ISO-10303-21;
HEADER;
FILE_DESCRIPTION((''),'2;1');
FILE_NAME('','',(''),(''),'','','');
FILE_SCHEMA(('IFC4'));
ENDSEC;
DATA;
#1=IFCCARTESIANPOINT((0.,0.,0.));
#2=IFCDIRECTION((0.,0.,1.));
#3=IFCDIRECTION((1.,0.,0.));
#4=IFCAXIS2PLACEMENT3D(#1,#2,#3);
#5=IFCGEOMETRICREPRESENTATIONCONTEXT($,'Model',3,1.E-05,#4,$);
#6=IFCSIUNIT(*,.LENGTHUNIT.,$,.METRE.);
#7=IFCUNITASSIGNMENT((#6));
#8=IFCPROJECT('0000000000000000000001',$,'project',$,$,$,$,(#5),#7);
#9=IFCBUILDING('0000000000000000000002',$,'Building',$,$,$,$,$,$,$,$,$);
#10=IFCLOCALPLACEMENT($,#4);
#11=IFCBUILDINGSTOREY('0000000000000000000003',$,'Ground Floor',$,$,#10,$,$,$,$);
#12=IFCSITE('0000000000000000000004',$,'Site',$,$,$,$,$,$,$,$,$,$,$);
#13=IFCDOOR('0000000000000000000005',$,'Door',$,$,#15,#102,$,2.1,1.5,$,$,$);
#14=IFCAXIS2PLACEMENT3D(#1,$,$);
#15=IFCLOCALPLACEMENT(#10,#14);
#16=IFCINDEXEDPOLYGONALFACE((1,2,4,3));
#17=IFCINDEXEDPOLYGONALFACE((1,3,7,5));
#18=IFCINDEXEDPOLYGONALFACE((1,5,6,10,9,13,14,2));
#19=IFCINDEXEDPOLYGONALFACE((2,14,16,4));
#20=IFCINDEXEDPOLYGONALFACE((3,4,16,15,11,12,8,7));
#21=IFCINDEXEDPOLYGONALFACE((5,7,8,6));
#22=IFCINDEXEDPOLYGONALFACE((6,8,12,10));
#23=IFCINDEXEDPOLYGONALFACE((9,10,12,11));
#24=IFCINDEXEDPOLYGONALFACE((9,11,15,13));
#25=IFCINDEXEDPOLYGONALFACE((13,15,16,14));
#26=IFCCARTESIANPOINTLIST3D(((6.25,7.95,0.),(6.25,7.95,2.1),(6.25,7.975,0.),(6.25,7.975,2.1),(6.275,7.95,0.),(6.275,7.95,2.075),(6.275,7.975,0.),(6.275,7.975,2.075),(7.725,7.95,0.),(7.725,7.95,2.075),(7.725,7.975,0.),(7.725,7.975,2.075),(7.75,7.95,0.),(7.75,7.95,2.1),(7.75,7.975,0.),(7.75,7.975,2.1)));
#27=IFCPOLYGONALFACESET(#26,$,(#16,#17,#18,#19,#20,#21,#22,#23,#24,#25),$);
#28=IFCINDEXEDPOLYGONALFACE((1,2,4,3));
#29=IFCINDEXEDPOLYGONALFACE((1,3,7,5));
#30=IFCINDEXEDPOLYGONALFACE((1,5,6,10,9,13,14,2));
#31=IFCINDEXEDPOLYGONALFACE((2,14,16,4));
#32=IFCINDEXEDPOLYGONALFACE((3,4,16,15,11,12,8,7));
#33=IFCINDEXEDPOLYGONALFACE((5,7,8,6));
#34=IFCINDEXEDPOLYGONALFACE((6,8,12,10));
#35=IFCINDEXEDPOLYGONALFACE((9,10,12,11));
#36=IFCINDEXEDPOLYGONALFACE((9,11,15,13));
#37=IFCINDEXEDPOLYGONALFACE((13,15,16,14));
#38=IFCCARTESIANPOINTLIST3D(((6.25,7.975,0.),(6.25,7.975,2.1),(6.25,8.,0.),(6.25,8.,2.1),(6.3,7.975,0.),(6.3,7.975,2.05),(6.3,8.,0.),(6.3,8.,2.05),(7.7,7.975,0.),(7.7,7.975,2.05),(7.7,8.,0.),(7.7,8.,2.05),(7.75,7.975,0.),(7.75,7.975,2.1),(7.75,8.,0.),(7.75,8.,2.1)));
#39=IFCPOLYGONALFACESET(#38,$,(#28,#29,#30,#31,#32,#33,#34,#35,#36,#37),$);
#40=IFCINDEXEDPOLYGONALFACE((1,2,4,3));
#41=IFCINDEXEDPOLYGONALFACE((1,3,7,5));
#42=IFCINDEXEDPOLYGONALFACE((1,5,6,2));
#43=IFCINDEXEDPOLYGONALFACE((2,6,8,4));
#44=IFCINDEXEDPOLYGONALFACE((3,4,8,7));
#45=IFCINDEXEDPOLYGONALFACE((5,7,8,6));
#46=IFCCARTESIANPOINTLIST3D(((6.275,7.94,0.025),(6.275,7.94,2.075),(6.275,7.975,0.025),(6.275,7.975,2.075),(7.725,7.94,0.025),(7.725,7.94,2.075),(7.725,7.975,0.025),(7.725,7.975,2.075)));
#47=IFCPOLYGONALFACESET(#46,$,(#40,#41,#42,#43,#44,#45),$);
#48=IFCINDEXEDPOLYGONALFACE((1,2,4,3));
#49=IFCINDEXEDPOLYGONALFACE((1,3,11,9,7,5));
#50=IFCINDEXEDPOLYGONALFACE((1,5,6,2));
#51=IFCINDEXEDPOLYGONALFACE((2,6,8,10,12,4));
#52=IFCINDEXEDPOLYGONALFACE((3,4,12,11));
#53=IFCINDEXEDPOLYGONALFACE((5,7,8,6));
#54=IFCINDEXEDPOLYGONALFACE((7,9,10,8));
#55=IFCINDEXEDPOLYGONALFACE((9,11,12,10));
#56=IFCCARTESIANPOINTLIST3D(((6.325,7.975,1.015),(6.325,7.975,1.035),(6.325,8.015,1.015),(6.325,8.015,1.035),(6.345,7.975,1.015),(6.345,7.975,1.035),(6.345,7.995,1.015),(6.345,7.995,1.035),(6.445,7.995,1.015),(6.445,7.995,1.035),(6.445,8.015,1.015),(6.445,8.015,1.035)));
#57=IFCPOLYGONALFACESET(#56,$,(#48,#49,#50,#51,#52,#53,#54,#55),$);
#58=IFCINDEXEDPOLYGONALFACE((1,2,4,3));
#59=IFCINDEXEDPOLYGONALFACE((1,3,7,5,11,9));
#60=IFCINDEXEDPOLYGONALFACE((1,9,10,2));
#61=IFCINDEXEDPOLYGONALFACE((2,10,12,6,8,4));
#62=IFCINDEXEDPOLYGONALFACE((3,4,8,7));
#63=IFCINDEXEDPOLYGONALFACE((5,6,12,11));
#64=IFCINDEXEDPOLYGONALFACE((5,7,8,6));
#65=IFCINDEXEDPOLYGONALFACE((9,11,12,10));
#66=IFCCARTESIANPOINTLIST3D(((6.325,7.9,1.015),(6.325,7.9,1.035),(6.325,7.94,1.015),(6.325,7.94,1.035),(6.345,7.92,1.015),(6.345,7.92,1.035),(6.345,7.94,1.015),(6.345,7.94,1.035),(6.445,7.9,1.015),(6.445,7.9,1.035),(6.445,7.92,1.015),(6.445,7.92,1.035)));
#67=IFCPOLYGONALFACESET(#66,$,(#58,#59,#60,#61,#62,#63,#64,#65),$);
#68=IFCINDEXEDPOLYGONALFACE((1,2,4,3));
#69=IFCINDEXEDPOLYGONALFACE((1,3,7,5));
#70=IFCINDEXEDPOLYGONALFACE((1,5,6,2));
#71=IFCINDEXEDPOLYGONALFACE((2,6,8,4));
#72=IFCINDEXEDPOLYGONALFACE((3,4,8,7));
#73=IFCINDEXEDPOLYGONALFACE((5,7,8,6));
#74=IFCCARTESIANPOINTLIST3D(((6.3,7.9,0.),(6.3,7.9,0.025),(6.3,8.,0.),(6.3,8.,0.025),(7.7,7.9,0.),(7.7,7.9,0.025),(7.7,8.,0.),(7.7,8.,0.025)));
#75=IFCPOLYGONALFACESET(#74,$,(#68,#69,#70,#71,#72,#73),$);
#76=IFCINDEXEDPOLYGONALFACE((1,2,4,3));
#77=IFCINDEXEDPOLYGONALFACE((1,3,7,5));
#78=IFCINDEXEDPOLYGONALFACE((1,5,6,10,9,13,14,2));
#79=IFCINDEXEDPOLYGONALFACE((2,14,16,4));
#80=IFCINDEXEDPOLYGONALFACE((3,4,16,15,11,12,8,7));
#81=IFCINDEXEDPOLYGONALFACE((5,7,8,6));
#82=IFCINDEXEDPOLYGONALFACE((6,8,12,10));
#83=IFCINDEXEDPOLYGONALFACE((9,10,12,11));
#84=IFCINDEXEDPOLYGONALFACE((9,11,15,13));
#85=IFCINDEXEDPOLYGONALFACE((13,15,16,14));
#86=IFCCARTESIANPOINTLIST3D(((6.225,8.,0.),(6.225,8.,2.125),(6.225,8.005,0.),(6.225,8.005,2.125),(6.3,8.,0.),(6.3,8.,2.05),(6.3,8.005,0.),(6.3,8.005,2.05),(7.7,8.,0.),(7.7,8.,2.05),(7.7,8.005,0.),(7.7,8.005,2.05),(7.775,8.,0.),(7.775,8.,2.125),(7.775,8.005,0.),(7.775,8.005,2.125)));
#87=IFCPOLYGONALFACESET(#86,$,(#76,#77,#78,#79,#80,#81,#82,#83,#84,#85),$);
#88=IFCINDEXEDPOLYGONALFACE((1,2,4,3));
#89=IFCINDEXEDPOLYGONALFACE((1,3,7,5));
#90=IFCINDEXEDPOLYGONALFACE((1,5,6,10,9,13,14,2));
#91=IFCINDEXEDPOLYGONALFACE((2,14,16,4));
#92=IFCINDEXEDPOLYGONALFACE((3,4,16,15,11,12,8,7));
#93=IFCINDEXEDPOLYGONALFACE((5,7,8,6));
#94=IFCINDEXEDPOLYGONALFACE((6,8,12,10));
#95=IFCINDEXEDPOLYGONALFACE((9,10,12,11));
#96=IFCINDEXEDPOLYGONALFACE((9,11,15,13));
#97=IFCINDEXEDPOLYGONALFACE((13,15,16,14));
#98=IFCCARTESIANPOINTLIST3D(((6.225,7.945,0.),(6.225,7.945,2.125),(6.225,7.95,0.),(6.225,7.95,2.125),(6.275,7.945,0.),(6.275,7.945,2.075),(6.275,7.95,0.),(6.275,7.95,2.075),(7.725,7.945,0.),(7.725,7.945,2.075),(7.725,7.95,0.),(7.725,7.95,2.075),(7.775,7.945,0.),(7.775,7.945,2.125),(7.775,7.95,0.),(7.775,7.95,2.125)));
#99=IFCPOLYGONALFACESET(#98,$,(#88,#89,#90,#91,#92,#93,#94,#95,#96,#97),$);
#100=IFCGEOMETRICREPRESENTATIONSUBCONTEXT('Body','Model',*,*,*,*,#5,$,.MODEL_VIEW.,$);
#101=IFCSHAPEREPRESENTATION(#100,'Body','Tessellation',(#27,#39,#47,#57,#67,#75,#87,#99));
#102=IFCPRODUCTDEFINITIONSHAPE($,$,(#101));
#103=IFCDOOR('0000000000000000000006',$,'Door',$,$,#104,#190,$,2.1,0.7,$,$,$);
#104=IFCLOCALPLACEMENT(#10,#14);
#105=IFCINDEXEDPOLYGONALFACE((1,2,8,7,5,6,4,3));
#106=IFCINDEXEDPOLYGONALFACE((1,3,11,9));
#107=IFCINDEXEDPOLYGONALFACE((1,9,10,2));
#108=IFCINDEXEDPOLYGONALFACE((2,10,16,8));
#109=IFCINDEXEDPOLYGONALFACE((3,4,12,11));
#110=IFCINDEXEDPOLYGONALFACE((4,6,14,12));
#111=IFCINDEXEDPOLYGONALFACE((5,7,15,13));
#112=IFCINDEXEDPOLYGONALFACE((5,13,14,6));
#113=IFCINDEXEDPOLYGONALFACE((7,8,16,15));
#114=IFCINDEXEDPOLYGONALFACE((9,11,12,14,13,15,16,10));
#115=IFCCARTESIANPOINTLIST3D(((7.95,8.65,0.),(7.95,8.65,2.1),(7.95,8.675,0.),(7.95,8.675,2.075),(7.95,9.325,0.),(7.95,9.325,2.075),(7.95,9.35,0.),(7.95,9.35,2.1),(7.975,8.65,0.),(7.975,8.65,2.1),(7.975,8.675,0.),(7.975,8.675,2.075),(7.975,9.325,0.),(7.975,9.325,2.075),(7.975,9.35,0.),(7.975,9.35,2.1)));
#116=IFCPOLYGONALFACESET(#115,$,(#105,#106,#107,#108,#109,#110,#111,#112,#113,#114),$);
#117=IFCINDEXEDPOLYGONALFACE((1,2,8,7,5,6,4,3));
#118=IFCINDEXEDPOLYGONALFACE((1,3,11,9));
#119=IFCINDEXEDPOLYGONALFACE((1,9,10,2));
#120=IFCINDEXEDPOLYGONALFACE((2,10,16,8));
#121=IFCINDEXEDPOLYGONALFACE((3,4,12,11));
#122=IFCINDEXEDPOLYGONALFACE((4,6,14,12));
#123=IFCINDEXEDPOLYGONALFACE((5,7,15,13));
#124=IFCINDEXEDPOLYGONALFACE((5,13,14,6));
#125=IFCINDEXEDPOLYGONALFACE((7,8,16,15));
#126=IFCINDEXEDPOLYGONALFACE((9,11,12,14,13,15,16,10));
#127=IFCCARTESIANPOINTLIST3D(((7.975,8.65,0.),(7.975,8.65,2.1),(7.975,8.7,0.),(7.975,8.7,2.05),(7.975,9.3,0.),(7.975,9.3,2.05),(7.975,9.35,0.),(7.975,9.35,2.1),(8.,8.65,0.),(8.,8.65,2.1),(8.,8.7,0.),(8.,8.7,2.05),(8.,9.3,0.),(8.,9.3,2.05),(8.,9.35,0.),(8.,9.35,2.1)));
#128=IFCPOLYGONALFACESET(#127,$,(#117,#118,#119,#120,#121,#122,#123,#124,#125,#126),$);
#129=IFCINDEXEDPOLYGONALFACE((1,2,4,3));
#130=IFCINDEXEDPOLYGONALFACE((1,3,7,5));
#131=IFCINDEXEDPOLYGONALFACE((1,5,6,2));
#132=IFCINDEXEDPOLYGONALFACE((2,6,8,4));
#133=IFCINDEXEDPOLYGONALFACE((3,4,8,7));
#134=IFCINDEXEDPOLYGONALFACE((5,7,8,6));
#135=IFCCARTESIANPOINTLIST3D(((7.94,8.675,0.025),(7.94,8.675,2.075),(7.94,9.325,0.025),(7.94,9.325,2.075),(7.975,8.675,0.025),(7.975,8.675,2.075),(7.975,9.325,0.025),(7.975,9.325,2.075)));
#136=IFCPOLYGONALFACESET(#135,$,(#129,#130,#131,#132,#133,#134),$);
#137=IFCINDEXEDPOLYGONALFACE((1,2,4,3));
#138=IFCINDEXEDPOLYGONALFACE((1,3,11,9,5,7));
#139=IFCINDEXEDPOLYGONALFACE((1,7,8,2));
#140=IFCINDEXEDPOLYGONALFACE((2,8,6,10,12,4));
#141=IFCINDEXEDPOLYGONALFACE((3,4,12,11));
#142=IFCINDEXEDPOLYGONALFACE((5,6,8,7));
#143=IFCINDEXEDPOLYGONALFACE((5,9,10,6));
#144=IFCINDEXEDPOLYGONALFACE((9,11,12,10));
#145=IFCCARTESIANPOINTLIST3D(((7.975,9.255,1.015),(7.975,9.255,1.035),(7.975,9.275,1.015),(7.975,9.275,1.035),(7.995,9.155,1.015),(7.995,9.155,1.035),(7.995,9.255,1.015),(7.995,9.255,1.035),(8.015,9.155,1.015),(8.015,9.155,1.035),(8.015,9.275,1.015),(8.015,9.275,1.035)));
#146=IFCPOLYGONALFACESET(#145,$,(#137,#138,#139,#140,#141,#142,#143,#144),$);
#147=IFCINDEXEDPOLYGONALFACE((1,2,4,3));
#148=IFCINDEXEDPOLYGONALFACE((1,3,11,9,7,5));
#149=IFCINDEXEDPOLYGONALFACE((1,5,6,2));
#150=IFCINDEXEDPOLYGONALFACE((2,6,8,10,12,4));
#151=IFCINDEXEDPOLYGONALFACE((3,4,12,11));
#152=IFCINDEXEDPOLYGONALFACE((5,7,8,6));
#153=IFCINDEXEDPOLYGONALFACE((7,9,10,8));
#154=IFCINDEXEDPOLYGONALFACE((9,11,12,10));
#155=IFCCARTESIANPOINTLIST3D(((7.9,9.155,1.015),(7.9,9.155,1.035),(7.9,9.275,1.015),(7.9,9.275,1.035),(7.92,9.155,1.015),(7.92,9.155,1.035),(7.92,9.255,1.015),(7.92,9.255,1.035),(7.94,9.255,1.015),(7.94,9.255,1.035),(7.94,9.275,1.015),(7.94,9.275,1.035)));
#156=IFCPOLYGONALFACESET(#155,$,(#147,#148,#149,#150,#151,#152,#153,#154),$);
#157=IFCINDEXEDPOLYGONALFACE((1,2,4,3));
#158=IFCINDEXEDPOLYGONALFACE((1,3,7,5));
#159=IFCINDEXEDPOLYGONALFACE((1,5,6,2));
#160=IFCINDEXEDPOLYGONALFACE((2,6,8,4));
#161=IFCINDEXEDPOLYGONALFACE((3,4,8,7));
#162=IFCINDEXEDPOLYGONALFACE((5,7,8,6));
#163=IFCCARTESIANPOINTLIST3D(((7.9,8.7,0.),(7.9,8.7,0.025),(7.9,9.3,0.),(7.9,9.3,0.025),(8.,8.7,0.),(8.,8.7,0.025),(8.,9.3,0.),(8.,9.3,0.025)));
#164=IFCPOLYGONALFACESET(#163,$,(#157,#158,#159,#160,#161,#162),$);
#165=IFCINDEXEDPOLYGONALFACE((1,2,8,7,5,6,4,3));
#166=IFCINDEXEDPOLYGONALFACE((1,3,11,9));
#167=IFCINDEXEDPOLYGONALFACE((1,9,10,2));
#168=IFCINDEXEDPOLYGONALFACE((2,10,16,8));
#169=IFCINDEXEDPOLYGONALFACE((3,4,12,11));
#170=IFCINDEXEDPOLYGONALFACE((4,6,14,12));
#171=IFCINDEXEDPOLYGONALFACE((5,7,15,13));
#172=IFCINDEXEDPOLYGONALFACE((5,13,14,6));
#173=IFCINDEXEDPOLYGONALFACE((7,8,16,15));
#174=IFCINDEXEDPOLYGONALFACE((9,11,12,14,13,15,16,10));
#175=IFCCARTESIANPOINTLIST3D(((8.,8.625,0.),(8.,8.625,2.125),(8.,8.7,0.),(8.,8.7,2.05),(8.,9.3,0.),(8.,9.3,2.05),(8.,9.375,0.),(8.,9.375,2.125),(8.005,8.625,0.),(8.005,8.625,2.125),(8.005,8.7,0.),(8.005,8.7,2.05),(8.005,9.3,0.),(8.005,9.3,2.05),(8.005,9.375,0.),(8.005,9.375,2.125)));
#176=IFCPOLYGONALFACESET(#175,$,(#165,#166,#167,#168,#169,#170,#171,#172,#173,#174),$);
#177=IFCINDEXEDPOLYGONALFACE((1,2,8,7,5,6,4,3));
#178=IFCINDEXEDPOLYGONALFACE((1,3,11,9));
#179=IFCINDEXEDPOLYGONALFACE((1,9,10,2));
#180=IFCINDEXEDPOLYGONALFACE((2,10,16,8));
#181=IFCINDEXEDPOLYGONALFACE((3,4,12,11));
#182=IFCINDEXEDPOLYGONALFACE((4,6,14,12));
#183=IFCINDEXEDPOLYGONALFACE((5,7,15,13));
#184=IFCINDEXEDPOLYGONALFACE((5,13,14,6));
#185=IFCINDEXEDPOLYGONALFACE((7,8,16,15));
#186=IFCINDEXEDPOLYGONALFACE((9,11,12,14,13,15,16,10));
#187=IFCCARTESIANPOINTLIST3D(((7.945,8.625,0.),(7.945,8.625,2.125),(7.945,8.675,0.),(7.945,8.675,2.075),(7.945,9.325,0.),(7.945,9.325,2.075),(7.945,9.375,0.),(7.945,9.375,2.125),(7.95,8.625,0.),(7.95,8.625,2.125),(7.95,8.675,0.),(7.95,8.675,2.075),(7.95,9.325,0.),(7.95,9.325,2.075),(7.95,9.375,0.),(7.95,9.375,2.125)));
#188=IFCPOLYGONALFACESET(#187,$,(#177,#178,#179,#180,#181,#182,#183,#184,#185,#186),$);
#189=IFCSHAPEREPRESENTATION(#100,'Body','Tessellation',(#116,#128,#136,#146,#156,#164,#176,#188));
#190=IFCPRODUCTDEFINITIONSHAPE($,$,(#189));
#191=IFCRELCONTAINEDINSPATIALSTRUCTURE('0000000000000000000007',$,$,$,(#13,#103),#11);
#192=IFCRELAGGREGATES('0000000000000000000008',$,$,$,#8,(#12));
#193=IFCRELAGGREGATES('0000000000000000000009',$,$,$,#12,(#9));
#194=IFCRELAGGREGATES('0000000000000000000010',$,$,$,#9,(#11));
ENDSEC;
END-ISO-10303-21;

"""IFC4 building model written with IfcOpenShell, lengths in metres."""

from ifc_helpers import new_model, si_unit, frame, origin_with_axes, place, context, subcontext, project, spatial, line, indexed_curve, outline, extrude, element, save


model = new_model("IFC4")

# Units and contexts
model_context = context("Model", 3, precision=1e-05, world=origin_with_axes())
body_context = subcontext(model_context, "Body", "Model", "MODEL_VIEW")
ifc_project = project(units=[si_unit("LENGTHUNIT", "METRE")], contexts=[model_context])

# Site, building, storey
site = spatial("IfcSite", under=ifc_project, Name="Site")
building = spatial("IfcBuilding", under=site, Name="Building")
storey_placement = place(None, origin_with_axes())
storey = spatial("IfcBuildingStorey", under=building, at=storey_placement, Name="Ground Floor")

# Doors
door_1_placement = place(storey_placement, frame((7.75, 8.0, 0.0), z_axis=(0.0, 0.0, 1.0), x_axis=(-1.0, 0.0, 0.0)))
element("IfcDoor", 1, at=door_1_placement, inside=storey, Name="Door", OverallHeight=2.1, OverallWidth=1.5, context=body_context, shape_type="SweptSolid", body=[
    extrude(outline(indexed_curve([(0.0, 0.0), (0.0, 2.1), (1.5, 2.1), (1.5, 0.0), (1.475, 0.0), (1.475, 2.075), (0.025, 2.075), (0.025, 0.0)], segments=[line(1, 2, 3, 4, 5, 6, 7, 8, 1)])), frame((0.0, 0.025, 0.0), z_axis=(0.0, -1.0, 0.0), x_axis=(1.0, 0.0, 0.0)), (0.0, 0.0, -1.0), 0.025),
    extrude(outline(indexed_curve([(0.0, 0.0), (0.0, 2.1), (1.5, 2.1), (1.5, 0.0), (1.45, 0.0), (1.45, 2.05), (0.05, 2.05), (0.05, 0.0)], segments=[line(1, 2, 3, 4, 5, 6, 7, 8, 1)])), frame((0.0, 0.0, 0.0), z_axis=(0.0, -1.0, 0.0), x_axis=(1.0, 0.0, 0.0)), (0.0, 0.0, -1.0), 0.025),
    extrude(outline(indexed_curve([(0.0, 0.0), (1.45, 0.0), (1.45, 0.035), (0.0, 0.035)], segments=[line(1, 2, 3, 4, 1)])), frame((0.025, 0.025, 0.025), z_axis=(0.0, 0.0, 1.0), x_axis=(1.0, 0.0, 0.0)), (0.0, 0.0, 1.0), 2.05),
    extrude(outline(indexed_curve([(0.0, 0.0), (0.0, -0.04), (-0.12, -0.04), (-0.12, -0.02), (-0.02, -0.02), (-0.02, 0.0)], segments=[line(1, 2, 3, 4, 5, 6, 1)])), frame((1.425, 0.025, 1.015), z_axis=(0.0, 0.0, 1.0), x_axis=(1.0, 0.0, 0.0)), (0.0, 0.0, 1.0), 0.02),
    extrude(outline(indexed_curve([(0.0, 0.0), (0.0, 0.04), (-0.12, 0.04), (-0.12, 0.02), (-0.02, 0.02), (-0.02, 0.0)], segments=[line(1, 2, 3, 4, 5, 6, 1)])), frame((1.425, 0.06, 1.015), z_axis=(0.0, 0.0, 1.0), x_axis=(1.0, 0.0, 0.0)), (0.0, 0.0, 1.0), 0.02),
    extrude(outline(indexed_curve([(0.0, 0.0), (1.4, 0.0), (1.4, 0.1), (0.0, 0.1)], segments=[line(1, 2, 3, 4, 1)])), frame((0.05, 0.0, 0.0), z_axis=(0.0, 0.0, 1.0), x_axis=(1.0, 0.0, 0.0)), (0.0, 0.0, 1.0), 0.025),
    extrude(outline(indexed_curve([(0.0, 0.0), (0.0, 2.125), (1.55, 2.125), (1.55, 0.0), (1.475, 0.0), (1.475, 2.05), (0.075, 2.05), (0.075, 0.0)], segments=[line(1, 2, 3, 4, 5, 6, 7, 8, 1)])), frame((-0.025, -0.005, 0.0), z_axis=(0.0, -1.0, 0.0), x_axis=(1.0, 0.0, 0.0)), (0.0, 0.0, -1.0), 0.005),
    extrude(outline(indexed_curve([(0.0, 0.0), (0.0, 2.125), (1.55, 2.125), (1.55, 0.0), (1.5, 0.0), (1.5, 2.075), (0.05, 2.075), (0.05, 0.0)], segments=[line(1, 2, 3, 4, 5, 6, 7, 8, 1)])), frame((-0.025, 0.05, 0.0), z_axis=(0.0, -1.0, 0.0), x_axis=(1.0, 0.0, 0.0)), (0.0, 0.0, -1.0), 0.005),
])
door_2_placement = place(storey_placement, frame((8.0, 8.65, 0.0), z_axis=(0.0, 0.0, 1.0), x_axis=(0.0, 1.0, 0.0)))
element("IfcDoor", 2, at=door_2_placement, inside=storey, Name="Door", OverallHeight=2.1, OverallWidth=0.7, context=body_context, shape_type="SweptSolid", body=[
    extrude(outline(indexed_curve([(0.0, 0.0), (0.0, 2.1), (0.7, 2.1), (0.7, 0.0), (0.675, 0.0), (0.675, 2.075), (0.025, 2.075), (0.025, 0.0)], segments=[line(1, 2, 3, 4, 5, 6, 7, 8, 1)])), frame((0.0, 0.025, 0.0), z_axis=(0.0, -1.0, 0.0), x_axis=(1.0, 0.0, 0.0)), (0.0, 0.0, -1.0), 0.025),
    extrude(outline(indexed_curve([(0.0, 0.0), (0.0, 2.1), (0.7, 2.1), (0.7, 0.0), (0.65, 0.0), (0.65, 2.05), (0.05, 2.05), (0.05, 0.0)], segments=[line(1, 2, 3, 4, 5, 6, 7, 8, 1)])), frame((0.0, 0.0, 0.0), z_axis=(0.0, -1.0, 0.0), x_axis=(1.0, 0.0, 0.0)), (0.0, 0.0, -1.0), 0.025),
    extrude(outline(indexed_curve([(0.0, 0.0), (0.65, 0.0), (0.65, 0.035), (0.0, 0.035)], segments=[line(1, 2, 3, 4, 1)])), frame((0.025, 0.025, 0.025), z_axis=(0.0, 0.0, 1.0), x_axis=(1.0, 0.0, 0.0)), (0.0, 0.0, 1.0), 2.05),
    extrude(outline(indexed_curve([(0.0, 0.0), (0.0, -0.04), (-0.12, -0.04), (-0.12, -0.02), (-0.02, -0.02), (-0.02, 0.0)], segments=[line(1, 2, 3, 4, 5, 6, 1)])), frame((0.625, 0.025, 1.015), z_axis=(0.0, 0.0, 1.0), x_axis=(1.0, 0.0, 0.0)), (0.0, 0.0, 1.0), 0.02),
    extrude(outline(indexed_curve([(0.0, 0.0), (0.0, 0.04), (-0.12, 0.04), (-0.12, 0.02), (-0.02, 0.02), (-0.02, 0.0)], segments=[line(1, 2, 3, 4, 5, 6, 1)])), frame((0.625, 0.06, 1.015), z_axis=(0.0, 0.0, 1.0), x_axis=(1.0, 0.0, 0.0)), (0.0, 0.0, 1.0), 0.02),
    extrude(outline(indexed_curve([(0.0, 0.0), (0.6, 0.0), (0.6, 0.1), (0.0, 0.1)], segments=[line(1, 2, 3, 4, 1)])), frame((0.05, 0.0, 0.0), z_axis=(0.0, 0.0, 1.0), x_axis=(1.0, 0.0, 0.0)), (0.0, 0.0, 1.0), 0.025),
    extrude(outline(indexed_curve([(0.0, 0.0), (0.0, 2.125), (0.75, 2.125), (0.75, 0.0), (0.675, 0.0), (0.675, 2.05), (0.075, 2.05), (0.075, 0.0)], segments=[line(1, 2, 3, 4, 5, 6, 7, 8, 1)])), frame((-0.025, -0.005, 0.0), z_axis=(0.0, -1.0, 0.0), x_axis=(1.0, 0.0, 0.0)), (0.0, 0.0, -1.0), 0.005),
    extrude(outline(indexed_curve([(0.0, 0.0), (0.0, 2.125), (0.75, 2.125), (0.75, 0.0), (0.7, 0.0), (0.7, 2.075), (0.05, 2.075), (0.05, 0.0)], segments=[line(1, 2, 3, 4, 5, 6, 7, 8, 1)])), frame((-0.025, 0.05, 0.0), z_axis=(0.0, -1.0, 0.0), x_axis=(1.0, 0.0, 0.0)), (0.0, 0.0, -1.0), 0.005),
])

save(model, "model.ifc")
